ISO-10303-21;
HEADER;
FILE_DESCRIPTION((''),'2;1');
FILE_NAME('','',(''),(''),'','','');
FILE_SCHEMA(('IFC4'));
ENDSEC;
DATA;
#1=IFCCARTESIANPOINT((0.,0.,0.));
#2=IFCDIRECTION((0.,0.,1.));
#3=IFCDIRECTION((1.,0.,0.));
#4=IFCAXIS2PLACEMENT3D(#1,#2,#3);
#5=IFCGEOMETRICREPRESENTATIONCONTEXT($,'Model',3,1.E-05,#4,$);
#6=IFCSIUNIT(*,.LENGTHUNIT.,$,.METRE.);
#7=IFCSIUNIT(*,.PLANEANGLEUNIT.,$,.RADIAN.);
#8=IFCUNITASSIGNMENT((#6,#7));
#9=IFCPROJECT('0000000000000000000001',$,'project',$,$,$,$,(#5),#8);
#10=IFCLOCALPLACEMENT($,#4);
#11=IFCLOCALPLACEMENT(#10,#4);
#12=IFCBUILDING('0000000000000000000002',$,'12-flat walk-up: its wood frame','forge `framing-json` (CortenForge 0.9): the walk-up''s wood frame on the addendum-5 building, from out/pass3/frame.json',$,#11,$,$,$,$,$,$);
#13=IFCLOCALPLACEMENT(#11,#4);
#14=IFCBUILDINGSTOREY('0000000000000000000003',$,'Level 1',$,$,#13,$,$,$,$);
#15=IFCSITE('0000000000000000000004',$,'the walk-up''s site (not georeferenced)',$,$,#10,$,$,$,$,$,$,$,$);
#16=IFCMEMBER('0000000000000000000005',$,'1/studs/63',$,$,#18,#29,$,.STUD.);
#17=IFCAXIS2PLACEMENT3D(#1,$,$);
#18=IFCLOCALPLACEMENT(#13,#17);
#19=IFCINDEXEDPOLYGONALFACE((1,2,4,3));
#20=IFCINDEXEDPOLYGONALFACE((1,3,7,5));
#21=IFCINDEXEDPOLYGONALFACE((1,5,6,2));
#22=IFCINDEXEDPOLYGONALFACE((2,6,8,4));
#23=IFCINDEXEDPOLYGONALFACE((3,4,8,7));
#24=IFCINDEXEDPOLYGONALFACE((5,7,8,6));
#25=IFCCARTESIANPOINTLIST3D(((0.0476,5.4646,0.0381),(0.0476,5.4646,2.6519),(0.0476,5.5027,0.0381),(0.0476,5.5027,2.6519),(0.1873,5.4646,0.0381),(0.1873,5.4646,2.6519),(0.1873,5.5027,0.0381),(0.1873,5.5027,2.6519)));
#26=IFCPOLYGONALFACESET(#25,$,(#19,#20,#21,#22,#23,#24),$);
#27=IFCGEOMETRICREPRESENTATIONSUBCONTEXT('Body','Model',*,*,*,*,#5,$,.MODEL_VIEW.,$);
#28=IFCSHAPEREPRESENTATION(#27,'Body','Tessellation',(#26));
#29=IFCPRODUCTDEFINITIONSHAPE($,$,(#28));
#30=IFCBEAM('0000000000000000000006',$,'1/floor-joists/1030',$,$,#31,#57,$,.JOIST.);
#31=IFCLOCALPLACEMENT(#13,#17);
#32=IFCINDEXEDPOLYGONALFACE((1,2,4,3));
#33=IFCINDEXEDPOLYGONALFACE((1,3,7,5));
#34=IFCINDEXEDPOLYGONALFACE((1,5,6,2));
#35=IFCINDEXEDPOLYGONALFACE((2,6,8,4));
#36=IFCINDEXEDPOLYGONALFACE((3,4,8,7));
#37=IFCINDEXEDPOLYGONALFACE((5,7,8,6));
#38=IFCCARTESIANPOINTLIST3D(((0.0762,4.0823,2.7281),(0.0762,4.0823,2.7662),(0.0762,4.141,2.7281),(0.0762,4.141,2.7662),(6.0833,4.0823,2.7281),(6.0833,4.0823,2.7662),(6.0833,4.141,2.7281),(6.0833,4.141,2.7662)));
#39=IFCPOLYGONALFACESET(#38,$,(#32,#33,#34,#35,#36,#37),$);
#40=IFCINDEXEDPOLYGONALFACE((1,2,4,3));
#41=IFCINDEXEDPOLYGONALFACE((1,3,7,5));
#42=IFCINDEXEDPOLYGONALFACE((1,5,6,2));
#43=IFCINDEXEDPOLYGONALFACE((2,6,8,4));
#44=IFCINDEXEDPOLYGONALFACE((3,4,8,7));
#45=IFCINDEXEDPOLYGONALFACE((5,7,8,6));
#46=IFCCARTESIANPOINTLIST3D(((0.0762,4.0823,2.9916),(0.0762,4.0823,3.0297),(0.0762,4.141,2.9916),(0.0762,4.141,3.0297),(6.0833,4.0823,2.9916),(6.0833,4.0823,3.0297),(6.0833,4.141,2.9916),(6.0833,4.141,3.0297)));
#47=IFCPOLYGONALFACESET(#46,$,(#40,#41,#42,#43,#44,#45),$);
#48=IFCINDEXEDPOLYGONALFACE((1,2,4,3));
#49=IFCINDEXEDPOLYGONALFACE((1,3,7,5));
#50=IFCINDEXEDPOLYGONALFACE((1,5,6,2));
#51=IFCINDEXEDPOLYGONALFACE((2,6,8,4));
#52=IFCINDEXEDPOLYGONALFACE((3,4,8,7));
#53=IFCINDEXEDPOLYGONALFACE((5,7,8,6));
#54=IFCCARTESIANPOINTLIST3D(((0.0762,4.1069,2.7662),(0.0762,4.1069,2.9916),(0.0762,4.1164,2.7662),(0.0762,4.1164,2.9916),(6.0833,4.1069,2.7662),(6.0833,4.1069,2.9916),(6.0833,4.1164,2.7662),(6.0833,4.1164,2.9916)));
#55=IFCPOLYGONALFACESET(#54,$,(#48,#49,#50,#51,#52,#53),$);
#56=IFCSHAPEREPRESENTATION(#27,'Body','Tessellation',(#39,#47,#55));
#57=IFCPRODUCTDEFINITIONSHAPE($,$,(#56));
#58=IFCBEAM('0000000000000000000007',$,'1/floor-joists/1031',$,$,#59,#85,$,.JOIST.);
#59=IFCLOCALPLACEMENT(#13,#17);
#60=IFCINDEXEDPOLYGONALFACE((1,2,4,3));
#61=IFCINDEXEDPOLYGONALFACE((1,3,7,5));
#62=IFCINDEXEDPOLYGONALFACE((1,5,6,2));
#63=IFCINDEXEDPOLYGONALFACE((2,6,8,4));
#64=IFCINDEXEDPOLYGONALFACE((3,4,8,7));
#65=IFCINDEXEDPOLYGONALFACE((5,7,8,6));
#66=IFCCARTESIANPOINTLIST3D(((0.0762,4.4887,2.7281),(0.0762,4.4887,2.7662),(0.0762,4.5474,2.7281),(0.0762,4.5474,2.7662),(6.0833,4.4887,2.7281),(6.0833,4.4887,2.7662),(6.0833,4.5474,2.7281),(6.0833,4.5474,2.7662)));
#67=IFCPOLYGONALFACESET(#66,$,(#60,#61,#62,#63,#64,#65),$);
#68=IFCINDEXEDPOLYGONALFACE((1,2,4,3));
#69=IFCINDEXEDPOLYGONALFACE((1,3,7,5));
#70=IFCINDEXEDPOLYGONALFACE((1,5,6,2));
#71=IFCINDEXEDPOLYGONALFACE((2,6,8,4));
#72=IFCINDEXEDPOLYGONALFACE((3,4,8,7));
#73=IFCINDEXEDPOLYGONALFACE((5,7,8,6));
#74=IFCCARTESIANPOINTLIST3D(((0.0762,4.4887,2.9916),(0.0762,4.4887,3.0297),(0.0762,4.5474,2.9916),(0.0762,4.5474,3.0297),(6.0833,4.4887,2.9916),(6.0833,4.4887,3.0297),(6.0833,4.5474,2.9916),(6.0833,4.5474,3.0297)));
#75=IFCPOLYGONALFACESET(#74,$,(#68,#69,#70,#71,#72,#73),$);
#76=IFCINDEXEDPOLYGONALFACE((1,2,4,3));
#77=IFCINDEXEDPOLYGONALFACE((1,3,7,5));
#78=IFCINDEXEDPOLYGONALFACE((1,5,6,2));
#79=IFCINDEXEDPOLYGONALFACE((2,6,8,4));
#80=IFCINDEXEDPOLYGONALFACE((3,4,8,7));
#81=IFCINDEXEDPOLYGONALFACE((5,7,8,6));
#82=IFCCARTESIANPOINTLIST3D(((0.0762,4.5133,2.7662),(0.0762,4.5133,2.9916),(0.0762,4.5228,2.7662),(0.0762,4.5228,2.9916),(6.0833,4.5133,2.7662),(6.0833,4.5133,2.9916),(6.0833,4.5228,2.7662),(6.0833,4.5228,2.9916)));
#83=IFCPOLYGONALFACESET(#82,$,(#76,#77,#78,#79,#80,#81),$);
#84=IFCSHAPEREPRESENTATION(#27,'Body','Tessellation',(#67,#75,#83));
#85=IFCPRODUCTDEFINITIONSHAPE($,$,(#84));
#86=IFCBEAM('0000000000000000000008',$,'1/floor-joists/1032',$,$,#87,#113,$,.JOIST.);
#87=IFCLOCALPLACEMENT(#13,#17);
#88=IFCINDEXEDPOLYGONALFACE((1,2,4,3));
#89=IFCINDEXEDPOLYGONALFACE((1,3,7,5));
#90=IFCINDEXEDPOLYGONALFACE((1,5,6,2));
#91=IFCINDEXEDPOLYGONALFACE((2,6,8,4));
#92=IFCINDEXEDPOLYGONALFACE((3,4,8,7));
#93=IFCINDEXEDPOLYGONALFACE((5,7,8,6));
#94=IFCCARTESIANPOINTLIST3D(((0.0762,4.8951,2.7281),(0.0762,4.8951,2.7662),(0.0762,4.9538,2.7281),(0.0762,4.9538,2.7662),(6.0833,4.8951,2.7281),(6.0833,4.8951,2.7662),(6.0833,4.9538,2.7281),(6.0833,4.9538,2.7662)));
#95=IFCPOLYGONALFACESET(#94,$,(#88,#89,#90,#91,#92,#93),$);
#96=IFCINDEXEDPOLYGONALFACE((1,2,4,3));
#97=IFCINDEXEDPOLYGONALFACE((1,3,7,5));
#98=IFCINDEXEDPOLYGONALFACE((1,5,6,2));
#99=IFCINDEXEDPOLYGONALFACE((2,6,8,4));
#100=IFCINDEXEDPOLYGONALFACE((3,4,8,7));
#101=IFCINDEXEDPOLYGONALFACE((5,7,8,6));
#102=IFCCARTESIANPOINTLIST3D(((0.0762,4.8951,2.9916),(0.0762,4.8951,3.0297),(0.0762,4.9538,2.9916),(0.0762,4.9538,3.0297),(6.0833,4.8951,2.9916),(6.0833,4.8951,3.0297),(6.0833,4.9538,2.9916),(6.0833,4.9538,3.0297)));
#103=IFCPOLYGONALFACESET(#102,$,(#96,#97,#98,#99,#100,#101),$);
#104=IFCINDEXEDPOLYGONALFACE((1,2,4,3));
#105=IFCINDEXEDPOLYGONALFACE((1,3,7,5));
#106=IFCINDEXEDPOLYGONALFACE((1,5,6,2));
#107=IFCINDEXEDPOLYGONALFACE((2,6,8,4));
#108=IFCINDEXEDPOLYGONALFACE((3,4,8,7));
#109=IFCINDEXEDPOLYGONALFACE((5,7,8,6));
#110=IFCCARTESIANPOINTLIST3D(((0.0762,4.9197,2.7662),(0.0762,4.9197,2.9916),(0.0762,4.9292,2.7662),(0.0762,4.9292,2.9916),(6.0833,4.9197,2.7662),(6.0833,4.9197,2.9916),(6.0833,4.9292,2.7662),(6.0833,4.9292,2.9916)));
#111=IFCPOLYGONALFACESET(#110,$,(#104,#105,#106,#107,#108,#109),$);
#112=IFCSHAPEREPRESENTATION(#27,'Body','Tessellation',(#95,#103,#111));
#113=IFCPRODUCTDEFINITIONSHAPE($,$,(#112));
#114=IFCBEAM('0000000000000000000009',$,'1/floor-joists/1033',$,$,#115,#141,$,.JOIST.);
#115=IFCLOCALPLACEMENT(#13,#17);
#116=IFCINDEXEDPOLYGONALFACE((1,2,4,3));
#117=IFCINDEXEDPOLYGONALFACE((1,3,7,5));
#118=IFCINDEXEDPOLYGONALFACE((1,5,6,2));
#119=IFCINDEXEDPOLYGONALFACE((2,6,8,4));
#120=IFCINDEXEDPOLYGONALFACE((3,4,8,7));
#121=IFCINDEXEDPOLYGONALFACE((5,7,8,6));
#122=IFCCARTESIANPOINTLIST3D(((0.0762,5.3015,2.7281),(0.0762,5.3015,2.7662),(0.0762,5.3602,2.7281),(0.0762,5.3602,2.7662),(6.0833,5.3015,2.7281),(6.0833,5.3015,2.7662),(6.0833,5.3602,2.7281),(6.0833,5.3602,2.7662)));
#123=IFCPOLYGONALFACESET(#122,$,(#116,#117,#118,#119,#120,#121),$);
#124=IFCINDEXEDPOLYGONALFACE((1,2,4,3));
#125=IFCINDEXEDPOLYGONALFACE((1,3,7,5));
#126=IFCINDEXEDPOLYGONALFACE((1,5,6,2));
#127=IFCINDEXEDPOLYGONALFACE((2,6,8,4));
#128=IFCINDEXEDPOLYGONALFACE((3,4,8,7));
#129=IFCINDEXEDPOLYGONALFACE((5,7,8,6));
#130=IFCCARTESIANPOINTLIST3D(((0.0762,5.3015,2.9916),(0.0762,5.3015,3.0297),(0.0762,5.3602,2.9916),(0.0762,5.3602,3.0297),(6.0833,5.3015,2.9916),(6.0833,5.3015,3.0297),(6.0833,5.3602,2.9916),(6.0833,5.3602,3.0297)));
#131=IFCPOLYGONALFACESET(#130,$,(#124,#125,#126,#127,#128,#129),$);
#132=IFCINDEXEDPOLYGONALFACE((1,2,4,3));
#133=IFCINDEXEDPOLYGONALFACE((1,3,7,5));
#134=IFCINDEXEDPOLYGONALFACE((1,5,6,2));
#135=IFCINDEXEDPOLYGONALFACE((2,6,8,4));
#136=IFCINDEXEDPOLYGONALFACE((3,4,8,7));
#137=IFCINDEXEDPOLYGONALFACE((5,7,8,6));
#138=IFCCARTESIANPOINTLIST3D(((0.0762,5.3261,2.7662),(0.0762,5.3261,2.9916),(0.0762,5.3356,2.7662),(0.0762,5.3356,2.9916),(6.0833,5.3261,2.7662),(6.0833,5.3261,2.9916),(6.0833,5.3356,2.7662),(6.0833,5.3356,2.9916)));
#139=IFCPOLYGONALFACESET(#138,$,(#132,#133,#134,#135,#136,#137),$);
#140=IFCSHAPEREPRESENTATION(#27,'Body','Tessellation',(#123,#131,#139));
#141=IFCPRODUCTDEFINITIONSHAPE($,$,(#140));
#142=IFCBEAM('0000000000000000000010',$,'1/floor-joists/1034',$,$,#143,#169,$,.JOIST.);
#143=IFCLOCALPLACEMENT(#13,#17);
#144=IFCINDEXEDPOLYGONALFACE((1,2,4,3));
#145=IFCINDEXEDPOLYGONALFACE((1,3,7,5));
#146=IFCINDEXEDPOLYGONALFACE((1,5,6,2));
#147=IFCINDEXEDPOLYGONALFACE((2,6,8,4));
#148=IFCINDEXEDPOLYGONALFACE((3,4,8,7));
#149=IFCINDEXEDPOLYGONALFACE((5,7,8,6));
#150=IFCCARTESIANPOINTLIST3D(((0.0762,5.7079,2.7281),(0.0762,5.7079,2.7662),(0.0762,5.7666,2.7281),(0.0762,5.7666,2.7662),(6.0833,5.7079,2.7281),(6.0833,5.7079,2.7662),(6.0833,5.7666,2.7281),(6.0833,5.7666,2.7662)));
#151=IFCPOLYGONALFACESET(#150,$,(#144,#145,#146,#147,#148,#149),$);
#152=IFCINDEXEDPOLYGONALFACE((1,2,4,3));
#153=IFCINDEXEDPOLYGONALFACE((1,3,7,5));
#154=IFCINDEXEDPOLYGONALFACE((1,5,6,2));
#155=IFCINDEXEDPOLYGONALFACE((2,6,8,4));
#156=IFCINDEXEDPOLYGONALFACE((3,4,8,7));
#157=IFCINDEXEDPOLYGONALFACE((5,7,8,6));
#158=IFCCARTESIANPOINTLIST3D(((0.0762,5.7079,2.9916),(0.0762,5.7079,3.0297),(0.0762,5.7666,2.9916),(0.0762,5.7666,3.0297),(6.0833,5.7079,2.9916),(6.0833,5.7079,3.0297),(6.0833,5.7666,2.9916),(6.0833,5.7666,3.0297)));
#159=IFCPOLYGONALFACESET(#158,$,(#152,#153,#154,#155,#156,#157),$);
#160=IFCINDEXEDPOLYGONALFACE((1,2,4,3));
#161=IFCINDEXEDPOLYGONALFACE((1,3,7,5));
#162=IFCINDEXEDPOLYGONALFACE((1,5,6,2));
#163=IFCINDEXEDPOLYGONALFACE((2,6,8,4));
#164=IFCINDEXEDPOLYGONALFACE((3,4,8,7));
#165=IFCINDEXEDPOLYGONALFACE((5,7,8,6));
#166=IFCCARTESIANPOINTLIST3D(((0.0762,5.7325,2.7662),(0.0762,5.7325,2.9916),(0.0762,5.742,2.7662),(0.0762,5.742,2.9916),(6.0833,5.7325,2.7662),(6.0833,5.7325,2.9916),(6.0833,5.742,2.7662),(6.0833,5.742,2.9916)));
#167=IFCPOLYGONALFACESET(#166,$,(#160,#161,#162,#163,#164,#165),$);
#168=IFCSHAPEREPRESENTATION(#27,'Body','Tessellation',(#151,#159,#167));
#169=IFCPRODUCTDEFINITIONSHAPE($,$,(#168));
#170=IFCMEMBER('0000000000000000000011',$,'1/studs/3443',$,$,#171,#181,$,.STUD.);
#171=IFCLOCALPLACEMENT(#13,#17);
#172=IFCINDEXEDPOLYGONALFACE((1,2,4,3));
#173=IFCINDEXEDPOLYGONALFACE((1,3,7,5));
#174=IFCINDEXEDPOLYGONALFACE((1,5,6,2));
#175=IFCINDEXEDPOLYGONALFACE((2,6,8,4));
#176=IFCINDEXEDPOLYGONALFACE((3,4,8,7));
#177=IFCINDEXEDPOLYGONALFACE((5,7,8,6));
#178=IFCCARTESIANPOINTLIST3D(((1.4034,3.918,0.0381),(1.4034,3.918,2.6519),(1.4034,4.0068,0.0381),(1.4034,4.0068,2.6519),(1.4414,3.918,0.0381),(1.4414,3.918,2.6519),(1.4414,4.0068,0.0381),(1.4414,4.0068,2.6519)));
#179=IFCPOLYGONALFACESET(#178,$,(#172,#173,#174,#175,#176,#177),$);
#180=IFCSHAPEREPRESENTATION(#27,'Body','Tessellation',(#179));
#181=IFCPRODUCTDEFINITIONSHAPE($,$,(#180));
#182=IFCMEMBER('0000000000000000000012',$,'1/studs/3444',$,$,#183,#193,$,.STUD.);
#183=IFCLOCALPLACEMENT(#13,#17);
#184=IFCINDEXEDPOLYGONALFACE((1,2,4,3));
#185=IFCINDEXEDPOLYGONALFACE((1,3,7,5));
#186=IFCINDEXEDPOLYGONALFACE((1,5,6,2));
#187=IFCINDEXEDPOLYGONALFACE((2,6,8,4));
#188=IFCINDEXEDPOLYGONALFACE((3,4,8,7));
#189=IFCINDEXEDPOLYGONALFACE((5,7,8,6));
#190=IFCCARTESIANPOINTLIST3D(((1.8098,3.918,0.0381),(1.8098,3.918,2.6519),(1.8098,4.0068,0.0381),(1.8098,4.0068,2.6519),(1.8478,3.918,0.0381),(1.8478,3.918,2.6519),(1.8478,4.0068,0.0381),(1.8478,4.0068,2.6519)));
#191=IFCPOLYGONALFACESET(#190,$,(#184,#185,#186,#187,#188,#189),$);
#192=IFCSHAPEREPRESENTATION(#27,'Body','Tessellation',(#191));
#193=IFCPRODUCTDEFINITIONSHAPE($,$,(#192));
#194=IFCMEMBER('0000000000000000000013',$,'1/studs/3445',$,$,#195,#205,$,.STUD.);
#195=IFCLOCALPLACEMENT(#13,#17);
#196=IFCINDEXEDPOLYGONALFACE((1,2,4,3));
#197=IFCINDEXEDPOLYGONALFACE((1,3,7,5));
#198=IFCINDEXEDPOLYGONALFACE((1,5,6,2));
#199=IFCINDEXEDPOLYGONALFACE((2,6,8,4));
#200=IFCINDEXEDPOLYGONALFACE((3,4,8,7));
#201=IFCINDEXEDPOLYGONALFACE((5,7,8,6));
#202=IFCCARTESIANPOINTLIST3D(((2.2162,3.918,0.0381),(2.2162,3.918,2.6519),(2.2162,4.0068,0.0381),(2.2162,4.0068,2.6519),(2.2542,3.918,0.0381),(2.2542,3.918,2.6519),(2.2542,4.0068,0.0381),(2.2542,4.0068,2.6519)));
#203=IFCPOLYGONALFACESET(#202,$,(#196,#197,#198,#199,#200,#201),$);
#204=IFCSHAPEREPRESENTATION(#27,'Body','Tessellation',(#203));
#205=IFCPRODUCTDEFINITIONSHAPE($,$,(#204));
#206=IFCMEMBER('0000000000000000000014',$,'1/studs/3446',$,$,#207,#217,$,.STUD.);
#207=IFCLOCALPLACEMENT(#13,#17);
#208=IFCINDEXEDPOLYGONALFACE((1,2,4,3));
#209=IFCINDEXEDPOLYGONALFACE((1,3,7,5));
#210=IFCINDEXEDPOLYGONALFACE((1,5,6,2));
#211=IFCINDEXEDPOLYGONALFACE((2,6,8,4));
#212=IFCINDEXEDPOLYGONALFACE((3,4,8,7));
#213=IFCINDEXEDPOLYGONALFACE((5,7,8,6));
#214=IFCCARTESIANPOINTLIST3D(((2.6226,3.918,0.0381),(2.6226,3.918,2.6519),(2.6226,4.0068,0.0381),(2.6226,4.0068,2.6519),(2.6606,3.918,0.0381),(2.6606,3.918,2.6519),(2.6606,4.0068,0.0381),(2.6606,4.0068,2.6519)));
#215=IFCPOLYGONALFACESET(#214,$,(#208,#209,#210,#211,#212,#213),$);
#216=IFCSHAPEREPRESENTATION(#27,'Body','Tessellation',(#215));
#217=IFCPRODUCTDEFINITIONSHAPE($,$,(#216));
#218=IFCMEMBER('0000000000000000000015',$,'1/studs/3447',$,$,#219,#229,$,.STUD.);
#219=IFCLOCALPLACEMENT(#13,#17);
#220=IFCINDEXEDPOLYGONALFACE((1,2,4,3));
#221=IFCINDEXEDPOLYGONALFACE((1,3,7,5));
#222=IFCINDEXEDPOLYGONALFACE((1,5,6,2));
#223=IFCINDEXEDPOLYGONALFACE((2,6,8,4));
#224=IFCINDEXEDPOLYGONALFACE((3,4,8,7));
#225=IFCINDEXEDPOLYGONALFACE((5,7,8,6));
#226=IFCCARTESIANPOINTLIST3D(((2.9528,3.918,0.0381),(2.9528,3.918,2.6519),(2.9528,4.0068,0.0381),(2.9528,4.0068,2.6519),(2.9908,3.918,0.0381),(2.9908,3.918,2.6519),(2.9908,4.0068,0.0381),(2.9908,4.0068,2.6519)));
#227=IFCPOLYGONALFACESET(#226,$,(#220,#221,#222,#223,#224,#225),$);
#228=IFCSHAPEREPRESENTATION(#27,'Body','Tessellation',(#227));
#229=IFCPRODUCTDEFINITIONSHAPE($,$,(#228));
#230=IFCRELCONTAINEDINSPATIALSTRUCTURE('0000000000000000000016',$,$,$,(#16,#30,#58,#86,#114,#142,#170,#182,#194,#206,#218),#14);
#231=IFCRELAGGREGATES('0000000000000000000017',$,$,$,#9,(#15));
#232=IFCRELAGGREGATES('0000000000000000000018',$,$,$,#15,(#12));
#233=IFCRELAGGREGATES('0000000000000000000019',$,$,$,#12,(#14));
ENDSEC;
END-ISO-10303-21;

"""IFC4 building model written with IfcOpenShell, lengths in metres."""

from ifc_helpers import new_model, si_unit, frame, frame_2d, origin, origin_with_axes, place, context, subcontext, project, spatial, rectangle, extrude, element, save


model = new_model("IFC4")

# Units and contexts
model_context = context("Model", 3, precision=1e-05, world=origin_with_axes())
body_context = subcontext(model_context, "Body", "Model", "MODEL_VIEW")
ifc_project = project(units=[si_unit("LENGTHUNIT", "METRE"), si_unit("PLANEANGLEUNIT", "RADIAN")], contexts=[model_context])

# Site, building, storey
site_placement = place(None, origin_with_axes())
site = spatial("IfcSite", under=ifc_project, at=site_placement, Name="the walk-up's site (not georeferenced)")
building_placement = place(site_placement, origin_with_axes())
building = spatial("IfcBuilding", under=site, at=building_placement, Name="12-flat walk-up: its wood frame", Description="forge `framing-json` (CortenForge 0.9): the walk-up's wood frame on the addendum-5 building, from out/pass3/frame.json")
storey_placement = place(building_placement, origin_with_axes())
storey = spatial("IfcBuildingStorey", under=building, at=storey_placement, Name="Level 1")

# Member
member_1_placement = place(storey_placement, frame((0.0476, 5.4646, 0.0381), z_axis=(0.0, 0.0, 1.0), x_axis=(1.0, 0.0, 0.0)))
element("IfcMember", 1, at=member_1_placement, inside=storey, Name="1/studs/63", PredefinedType="STUD", context=body_context, shape_type="SweptSolid", body=[
    extrude(rectangle(XDim=0.1397, YDim=0.0381, at=frame_2d((0.0698, 0.0191))), origin(), (0.0, 0.0, 1.0), 2.6138),
])

# Beams
beam_1_placement = place(storey_placement, frame((0.0762, 4.0823, 2.7281), z_axis=(0.0, 0.0, 1.0), x_axis=(1.0, 0.0, 0.0)))
element("IfcBeam", 2, at=beam_1_placement, inside=storey, Name="1/floor-joists/1030", PredefinedType="JOIST", context=body_context, shape_type="SweptSolid", body=[
    extrude(rectangle(XDim=6.0071, YDim=0.0587, at=frame_2d((3.0036, 0.0294))), origin(), (0.0, 0.0, 1.0), 0.0381),
    extrude(rectangle(XDim=6.0071, YDim=0.0587, at=frame_2d((3.0036, 0.0294))), frame((0.0, 0.0, 0.2635)), (0.0, 0.0, 1.0), 0.0381),
    extrude(rectangle(XDim=6.0071, YDim=0.0095, at=frame_2d((3.0036, 0.0048))), frame((0.0, 0.0246, 0.0381)), (0.0, 0.0, 1.0), 0.2254),
])
beam_2_placement = place(storey_placement, frame((0.0762, 4.4887, 2.7281), z_axis=(0.0, 0.0, 1.0), x_axis=(1.0, 0.0, 0.0)))
element("IfcBeam", 3, at=beam_2_placement, inside=storey, Name="1/floor-joists/1031", PredefinedType="JOIST", context=body_context, shape_type="SweptSolid", body=[
    extrude(rectangle(XDim=6.0071, YDim=0.0587, at=frame_2d((3.0036, 0.0294))), origin(), (0.0, 0.0, 1.0), 0.0381),
    extrude(rectangle(XDim=6.0071, YDim=0.0587, at=frame_2d((3.0036, 0.0294))), frame((0.0, 0.0, 0.2635)), (0.0, 0.0, 1.0), 0.0381),
    extrude(rectangle(XDim=6.0071, YDim=0.0095, at=frame_2d((3.0036, 0.0048))), frame((0.0, 0.0246, 0.0381)), (0.0, 0.0, 1.0), 0.2254),
])
beam_3_placement = place(storey_placement, frame((0.0762, 4.8951, 2.7281), z_axis=(0.0, 0.0, 1.0), x_axis=(1.0, 0.0, 0.0)))
element("IfcBeam", 4, at=beam_3_placement, inside=storey, Name="1/floor-joists/1032", PredefinedType="JOIST", context=body_context, shape_type="SweptSolid", body=[
    extrude(rectangle(XDim=6.0071, YDim=0.0587, at=frame_2d((3.0036, 0.0294))), origin(), (0.0, 0.0, 1.0), 0.0381),
    extrude(rectangle(XDim=6.0071, YDim=0.0587, at=frame_2d((3.0036, 0.0294))), frame((0.0, 0.0, 0.2635)), (0.0, 0.0, 1.0), 0.0381),
    extrude(rectangle(XDim=6.0071, YDim=0.0095, at=frame_2d((3.0036, 0.0048))), frame((0.0, 0.0246, 0.0381)), (0.0, 0.0, 1.0), 0.2254),
])
beam_4_placement = place(storey_placement, frame((0.0762, 5.3015, 2.7281), z_axis=(0.0, 0.0, 1.0), x_axis=(1.0, 0.0, 0.0)))
element("IfcBeam", 5, at=beam_4_placement, inside=storey, Name="1/floor-joists/1033", PredefinedType="JOIST", context=body_context, shape_type="SweptSolid", body=[
    extrude(rectangle(XDim=6.0071, YDim=0.0587, at=frame_2d((3.0036, 0.0294))), origin(), (0.0, 0.0, 1.0), 0.0381),
    extrude(rectangle(XDim=6.0071, YDim=0.0587, at=frame_2d((3.0036, 0.0294))), frame((0.0, 0.0, 0.2635)), (0.0, 0.0, 1.0), 0.0381),
    extrude(rectangle(XDim=6.0071, YDim=0.0095, at=frame_2d((3.0036, 0.0048))), frame((0.0, 0.0246, 0.0381)), (0.0, 0.0, 1.0), 0.2254),
])
beam_5_placement = place(storey_placement, frame((0.0762, 5.7079, 2.7281), z_axis=(0.0, 0.0, 1.0), x_axis=(1.0, 0.0, 0.0)))
element("IfcBeam", 6, at=beam_5_placement, inside=storey, Name="1/floor-joists/1034", PredefinedType="JOIST", context=body_context, shape_type="SweptSolid", body=[
    extrude(rectangle(XDim=6.0071, YDim=0.0587, at=frame_2d((3.0036, 0.0294))), origin(), (0.0, 0.0, 1.0), 0.0381),
    extrude(rectangle(XDim=6.0071, YDim=0.0587, at=frame_2d((3.0036, 0.0294))), frame((0.0, 0.0, 0.2635)), (0.0, 0.0, 1.0), 0.0381),
    extrude(rectangle(XDim=6.0071, YDim=0.0095, at=frame_2d((3.0036, 0.0048))), frame((0.0, 0.0246, 0.0381)), (0.0, 0.0, 1.0), 0.2254),
])

# Members
member_2_placement = place(storey_placement, frame((1.4034, 3.9179, 0.0381), z_axis=(0.0, 0.0, 1.0), x_axis=(1.0, 0.0, 0.0)))
element("IfcMember", 7, at=member_2_placement, inside=storey, Name="1/studs/3443", PredefinedType="STUD", context=body_context, shape_type="SweptSolid", body=[
    extrude(rectangle(XDim=0.0381, YDim=0.0889, at=frame_2d((0.019, 0.0445))), origin(), (0.0, 0.0, 1.0), 2.6138),
])
for number, where, z_axis, x_axis, name in (
    (8, (1.8097, 3.9179, 0.0381), (0.0, 0.0, 1.0), (1.0, 0.0, 0.0), "1/studs/3444"),
    (9, (2.2161, 3.9179, 0.0381), (0.0, 0.0, 1.0), (1.0, 0.0, 0.0), "1/studs/3445"),
    (10, (2.6225, 3.9179, 0.0381), (0.0, 0.0, 1.0), (1.0, 0.0, 0.0), "1/studs/3446"),
    (11, (2.9527, 3.9179, 0.0381), (0.0, 0.0, 1.0), (1.0, 0.0, 0.0), "1/studs/3447"),
):
    element("IfcMember", number, at=place(storey_placement, frame(where, z_axis=z_axis, x_axis=x_axis)), inside=storey, Name=name, PredefinedType="STUD", context=body_context, shape_type="SweptSolid", body=[
        extrude(rectangle(XDim=0.0381, YDim=0.0889, at=frame_2d((0.0191, 0.0445))), origin(), (0.0, 0.0, 1.0), 2.6138),
    ])

save(model, "model.ifc")
